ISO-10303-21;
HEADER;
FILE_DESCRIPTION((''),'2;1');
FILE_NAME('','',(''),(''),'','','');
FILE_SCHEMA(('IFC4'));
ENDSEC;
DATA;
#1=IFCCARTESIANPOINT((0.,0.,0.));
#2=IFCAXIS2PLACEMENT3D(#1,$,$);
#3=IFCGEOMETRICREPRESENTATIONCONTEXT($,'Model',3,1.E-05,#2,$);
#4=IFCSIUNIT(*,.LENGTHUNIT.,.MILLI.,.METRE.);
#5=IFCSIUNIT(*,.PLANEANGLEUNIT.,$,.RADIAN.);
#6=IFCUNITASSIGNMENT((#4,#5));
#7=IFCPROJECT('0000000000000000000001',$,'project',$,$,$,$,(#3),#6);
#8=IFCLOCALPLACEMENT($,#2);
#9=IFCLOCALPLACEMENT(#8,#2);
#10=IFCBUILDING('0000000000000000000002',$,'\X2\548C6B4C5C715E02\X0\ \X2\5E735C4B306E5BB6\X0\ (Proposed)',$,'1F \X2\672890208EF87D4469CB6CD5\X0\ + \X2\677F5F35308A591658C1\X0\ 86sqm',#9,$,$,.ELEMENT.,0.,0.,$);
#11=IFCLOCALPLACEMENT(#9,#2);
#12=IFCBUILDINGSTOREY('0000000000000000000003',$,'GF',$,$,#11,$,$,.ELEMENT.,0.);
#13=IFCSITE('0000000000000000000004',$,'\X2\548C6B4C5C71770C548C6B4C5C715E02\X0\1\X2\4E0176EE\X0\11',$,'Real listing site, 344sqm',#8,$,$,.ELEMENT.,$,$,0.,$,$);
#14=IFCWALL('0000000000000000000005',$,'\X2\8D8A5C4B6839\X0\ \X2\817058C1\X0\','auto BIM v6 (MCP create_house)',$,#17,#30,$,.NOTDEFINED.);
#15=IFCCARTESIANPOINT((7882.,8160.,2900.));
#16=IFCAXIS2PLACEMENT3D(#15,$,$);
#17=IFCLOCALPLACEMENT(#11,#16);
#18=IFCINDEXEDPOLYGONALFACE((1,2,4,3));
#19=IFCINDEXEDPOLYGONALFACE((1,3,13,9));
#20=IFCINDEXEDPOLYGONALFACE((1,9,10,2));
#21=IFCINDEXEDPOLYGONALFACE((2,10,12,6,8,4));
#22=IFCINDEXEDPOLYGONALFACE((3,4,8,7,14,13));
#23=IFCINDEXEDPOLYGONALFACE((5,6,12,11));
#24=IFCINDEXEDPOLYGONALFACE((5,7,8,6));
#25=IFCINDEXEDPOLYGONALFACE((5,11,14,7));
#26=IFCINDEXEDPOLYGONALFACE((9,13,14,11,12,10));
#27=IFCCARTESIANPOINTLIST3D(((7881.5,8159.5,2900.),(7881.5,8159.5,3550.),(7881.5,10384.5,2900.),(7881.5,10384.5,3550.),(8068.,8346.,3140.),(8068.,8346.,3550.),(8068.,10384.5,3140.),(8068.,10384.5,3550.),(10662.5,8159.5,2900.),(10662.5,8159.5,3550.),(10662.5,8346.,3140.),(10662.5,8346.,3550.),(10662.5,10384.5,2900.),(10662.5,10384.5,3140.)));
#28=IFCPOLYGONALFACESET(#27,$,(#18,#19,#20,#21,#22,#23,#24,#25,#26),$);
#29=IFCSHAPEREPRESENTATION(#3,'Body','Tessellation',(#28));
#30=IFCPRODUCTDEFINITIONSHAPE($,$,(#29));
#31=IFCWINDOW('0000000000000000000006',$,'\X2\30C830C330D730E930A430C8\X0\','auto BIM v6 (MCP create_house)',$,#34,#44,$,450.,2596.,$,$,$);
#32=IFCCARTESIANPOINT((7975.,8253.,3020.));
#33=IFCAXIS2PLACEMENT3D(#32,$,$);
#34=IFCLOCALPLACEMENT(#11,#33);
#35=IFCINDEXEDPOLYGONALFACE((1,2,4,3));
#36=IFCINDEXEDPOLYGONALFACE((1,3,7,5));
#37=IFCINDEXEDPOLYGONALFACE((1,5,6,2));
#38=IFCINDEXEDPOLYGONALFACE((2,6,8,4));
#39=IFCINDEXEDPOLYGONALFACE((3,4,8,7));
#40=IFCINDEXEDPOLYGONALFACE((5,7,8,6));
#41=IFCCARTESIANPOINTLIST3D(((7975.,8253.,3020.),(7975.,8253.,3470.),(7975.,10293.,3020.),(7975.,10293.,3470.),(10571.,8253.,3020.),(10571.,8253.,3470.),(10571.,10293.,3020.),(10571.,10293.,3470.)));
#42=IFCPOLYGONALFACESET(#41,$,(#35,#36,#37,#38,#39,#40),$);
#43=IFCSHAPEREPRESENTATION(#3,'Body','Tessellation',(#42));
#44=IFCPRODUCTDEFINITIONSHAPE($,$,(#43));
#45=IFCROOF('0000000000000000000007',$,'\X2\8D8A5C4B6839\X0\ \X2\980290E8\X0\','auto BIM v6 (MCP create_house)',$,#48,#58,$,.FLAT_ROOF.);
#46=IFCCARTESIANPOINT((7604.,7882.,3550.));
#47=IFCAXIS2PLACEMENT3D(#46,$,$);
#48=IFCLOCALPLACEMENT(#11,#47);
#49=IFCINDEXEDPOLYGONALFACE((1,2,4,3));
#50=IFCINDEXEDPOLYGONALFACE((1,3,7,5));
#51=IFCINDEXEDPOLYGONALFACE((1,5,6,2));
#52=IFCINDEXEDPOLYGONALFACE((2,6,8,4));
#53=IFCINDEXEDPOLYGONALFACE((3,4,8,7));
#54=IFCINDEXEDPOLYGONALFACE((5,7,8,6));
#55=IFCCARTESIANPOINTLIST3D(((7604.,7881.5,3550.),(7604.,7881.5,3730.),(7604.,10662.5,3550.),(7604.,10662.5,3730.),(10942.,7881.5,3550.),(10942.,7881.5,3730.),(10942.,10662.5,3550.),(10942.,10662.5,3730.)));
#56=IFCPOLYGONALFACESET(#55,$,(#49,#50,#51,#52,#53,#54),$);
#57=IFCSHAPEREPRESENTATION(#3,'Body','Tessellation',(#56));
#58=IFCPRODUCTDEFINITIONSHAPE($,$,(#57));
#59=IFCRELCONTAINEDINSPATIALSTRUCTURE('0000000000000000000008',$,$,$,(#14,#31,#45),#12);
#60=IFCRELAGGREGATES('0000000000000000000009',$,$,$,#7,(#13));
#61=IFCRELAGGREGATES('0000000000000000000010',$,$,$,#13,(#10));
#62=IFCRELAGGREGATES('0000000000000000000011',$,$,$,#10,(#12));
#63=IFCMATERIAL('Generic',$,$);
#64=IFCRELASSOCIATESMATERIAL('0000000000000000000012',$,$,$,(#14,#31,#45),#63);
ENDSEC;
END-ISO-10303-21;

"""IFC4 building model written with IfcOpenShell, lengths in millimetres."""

from ifc_helpers import new_model, si_unit, frame, frame_2d, origin, place, context, project, spatial, rectangle, extrude, material, element, fill, save


model = new_model("IFC4")

# Units and contexts
model_context = context("Model", 3, precision=1e-05, world=origin())
ifc_project = project(units=[si_unit("LENGTHUNIT", "METRE", prefix="MILLI"), si_unit("PLANEANGLEUNIT", "RADIAN")], contexts=[model_context])

# Site, building, storey
site_placement = place(None, origin())
site = spatial("IfcSite", under=ifc_project, at=site_placement, Name="和歌山県和歌山市1丁目11", ObjectType="Real listing site, 344sqm", CompositionType="ELEMENT", RefElevation=0.0)
building_placement = place(site_placement, origin())
building = spatial("IfcBuilding", under=site, at=building_placement, Name="和歌山市 平屋の家 (Proposed)", ObjectType="1F 木造軸組構法 + 板張り外壁 86sqm", CompositionType="ELEMENT", ElevationOfRefHeight=0.0, ElevationOfTerrain=0.0)
storey_placement = place(building_placement, origin())
storey = spatial("IfcBuildingStorey", under=building, at=storey_placement, Name="GF", CompositionType="ELEMENT", Elevation=0.0)

# Shared definitions
ifc_material = material(Name="Generic")

# Wall, opening, window
wall_1_placement = place(storey_placement, frame((7882.0, 8160.0, 2900.0)))
wall_1 = element("IfcWall", 1, at=wall_1_placement, inside=storey, material=ifc_material, Name="越屋根 腰壁", Description="auto BIM v6 (MCP create_house)", PredefinedType="NOTDEFINED", context=model_context, shape_type="SweptSolid", body=[
    extrude(rectangle(XDim=2781.0, YDim=2225.0, at=frame_2d((1390.0, 1112.0))), frame((7882.0, 8160.0, 2900.0)), (0.0, 0.0, 1.0), 650.0),
])
opening_1_placement = place(storey_placement, frame((7975.0, 8253.0, 3020.0)))
opening_1 = element("IfcOpeningElement", 2, at=opening_1_placement, cuts=wall_1, PredefinedType="NOTDEFINED", context=model_context, shape_type="SweptSolid", body=[
    extrude(rectangle(XDim=2596.0, YDim=2040.0, at=frame_2d((1298.0, 1020.0))), frame((7975.0, 8253.0, 3020.0)), (0.0, 0.0, 1.0), 450.0),
])
window_1_placement = place(storey_placement, frame((7975.0, 8253.0, 3020.0)))
window_1 = element("IfcWindow", 3, at=window_1_placement, inside=storey, material=ifc_material, Name="トップライト", Description="auto BIM v6 (MCP create_house)", OverallHeight=450.0, OverallWidth=2596.0, context=model_context, shape_type="SweptSolid", body=[
    extrude(rectangle(XDim=2596.0, YDim=2040.0, at=frame_2d((1298.0, 1020.0))), frame((7975.0, 8253.0, 3020.0)), (0.0, 0.0, 1.0), 450.0),
])
fill(opening_1, window_1)

# Roof
roof_1_placement = place(storey_placement, frame((7604.0, 7882.0, 3550.0)))
element("IfcRoof", 4, at=roof_1_placement, inside=storey, material=ifc_material, Name="越屋根 頂部", Description="auto BIM v6 (MCP create_house)", PredefinedType="FLAT_ROOF", context=model_context, shape_type="SweptSolid", body=[
    extrude(rectangle(XDim=3338.0, YDim=2781.0, at=frame_2d((1669.0, 1390.0))), frame((7604.0, 7882.0, 3550.0)), (0.0, 0.0, 1.0), 180.0),
])

save(model, "model.ifc")
